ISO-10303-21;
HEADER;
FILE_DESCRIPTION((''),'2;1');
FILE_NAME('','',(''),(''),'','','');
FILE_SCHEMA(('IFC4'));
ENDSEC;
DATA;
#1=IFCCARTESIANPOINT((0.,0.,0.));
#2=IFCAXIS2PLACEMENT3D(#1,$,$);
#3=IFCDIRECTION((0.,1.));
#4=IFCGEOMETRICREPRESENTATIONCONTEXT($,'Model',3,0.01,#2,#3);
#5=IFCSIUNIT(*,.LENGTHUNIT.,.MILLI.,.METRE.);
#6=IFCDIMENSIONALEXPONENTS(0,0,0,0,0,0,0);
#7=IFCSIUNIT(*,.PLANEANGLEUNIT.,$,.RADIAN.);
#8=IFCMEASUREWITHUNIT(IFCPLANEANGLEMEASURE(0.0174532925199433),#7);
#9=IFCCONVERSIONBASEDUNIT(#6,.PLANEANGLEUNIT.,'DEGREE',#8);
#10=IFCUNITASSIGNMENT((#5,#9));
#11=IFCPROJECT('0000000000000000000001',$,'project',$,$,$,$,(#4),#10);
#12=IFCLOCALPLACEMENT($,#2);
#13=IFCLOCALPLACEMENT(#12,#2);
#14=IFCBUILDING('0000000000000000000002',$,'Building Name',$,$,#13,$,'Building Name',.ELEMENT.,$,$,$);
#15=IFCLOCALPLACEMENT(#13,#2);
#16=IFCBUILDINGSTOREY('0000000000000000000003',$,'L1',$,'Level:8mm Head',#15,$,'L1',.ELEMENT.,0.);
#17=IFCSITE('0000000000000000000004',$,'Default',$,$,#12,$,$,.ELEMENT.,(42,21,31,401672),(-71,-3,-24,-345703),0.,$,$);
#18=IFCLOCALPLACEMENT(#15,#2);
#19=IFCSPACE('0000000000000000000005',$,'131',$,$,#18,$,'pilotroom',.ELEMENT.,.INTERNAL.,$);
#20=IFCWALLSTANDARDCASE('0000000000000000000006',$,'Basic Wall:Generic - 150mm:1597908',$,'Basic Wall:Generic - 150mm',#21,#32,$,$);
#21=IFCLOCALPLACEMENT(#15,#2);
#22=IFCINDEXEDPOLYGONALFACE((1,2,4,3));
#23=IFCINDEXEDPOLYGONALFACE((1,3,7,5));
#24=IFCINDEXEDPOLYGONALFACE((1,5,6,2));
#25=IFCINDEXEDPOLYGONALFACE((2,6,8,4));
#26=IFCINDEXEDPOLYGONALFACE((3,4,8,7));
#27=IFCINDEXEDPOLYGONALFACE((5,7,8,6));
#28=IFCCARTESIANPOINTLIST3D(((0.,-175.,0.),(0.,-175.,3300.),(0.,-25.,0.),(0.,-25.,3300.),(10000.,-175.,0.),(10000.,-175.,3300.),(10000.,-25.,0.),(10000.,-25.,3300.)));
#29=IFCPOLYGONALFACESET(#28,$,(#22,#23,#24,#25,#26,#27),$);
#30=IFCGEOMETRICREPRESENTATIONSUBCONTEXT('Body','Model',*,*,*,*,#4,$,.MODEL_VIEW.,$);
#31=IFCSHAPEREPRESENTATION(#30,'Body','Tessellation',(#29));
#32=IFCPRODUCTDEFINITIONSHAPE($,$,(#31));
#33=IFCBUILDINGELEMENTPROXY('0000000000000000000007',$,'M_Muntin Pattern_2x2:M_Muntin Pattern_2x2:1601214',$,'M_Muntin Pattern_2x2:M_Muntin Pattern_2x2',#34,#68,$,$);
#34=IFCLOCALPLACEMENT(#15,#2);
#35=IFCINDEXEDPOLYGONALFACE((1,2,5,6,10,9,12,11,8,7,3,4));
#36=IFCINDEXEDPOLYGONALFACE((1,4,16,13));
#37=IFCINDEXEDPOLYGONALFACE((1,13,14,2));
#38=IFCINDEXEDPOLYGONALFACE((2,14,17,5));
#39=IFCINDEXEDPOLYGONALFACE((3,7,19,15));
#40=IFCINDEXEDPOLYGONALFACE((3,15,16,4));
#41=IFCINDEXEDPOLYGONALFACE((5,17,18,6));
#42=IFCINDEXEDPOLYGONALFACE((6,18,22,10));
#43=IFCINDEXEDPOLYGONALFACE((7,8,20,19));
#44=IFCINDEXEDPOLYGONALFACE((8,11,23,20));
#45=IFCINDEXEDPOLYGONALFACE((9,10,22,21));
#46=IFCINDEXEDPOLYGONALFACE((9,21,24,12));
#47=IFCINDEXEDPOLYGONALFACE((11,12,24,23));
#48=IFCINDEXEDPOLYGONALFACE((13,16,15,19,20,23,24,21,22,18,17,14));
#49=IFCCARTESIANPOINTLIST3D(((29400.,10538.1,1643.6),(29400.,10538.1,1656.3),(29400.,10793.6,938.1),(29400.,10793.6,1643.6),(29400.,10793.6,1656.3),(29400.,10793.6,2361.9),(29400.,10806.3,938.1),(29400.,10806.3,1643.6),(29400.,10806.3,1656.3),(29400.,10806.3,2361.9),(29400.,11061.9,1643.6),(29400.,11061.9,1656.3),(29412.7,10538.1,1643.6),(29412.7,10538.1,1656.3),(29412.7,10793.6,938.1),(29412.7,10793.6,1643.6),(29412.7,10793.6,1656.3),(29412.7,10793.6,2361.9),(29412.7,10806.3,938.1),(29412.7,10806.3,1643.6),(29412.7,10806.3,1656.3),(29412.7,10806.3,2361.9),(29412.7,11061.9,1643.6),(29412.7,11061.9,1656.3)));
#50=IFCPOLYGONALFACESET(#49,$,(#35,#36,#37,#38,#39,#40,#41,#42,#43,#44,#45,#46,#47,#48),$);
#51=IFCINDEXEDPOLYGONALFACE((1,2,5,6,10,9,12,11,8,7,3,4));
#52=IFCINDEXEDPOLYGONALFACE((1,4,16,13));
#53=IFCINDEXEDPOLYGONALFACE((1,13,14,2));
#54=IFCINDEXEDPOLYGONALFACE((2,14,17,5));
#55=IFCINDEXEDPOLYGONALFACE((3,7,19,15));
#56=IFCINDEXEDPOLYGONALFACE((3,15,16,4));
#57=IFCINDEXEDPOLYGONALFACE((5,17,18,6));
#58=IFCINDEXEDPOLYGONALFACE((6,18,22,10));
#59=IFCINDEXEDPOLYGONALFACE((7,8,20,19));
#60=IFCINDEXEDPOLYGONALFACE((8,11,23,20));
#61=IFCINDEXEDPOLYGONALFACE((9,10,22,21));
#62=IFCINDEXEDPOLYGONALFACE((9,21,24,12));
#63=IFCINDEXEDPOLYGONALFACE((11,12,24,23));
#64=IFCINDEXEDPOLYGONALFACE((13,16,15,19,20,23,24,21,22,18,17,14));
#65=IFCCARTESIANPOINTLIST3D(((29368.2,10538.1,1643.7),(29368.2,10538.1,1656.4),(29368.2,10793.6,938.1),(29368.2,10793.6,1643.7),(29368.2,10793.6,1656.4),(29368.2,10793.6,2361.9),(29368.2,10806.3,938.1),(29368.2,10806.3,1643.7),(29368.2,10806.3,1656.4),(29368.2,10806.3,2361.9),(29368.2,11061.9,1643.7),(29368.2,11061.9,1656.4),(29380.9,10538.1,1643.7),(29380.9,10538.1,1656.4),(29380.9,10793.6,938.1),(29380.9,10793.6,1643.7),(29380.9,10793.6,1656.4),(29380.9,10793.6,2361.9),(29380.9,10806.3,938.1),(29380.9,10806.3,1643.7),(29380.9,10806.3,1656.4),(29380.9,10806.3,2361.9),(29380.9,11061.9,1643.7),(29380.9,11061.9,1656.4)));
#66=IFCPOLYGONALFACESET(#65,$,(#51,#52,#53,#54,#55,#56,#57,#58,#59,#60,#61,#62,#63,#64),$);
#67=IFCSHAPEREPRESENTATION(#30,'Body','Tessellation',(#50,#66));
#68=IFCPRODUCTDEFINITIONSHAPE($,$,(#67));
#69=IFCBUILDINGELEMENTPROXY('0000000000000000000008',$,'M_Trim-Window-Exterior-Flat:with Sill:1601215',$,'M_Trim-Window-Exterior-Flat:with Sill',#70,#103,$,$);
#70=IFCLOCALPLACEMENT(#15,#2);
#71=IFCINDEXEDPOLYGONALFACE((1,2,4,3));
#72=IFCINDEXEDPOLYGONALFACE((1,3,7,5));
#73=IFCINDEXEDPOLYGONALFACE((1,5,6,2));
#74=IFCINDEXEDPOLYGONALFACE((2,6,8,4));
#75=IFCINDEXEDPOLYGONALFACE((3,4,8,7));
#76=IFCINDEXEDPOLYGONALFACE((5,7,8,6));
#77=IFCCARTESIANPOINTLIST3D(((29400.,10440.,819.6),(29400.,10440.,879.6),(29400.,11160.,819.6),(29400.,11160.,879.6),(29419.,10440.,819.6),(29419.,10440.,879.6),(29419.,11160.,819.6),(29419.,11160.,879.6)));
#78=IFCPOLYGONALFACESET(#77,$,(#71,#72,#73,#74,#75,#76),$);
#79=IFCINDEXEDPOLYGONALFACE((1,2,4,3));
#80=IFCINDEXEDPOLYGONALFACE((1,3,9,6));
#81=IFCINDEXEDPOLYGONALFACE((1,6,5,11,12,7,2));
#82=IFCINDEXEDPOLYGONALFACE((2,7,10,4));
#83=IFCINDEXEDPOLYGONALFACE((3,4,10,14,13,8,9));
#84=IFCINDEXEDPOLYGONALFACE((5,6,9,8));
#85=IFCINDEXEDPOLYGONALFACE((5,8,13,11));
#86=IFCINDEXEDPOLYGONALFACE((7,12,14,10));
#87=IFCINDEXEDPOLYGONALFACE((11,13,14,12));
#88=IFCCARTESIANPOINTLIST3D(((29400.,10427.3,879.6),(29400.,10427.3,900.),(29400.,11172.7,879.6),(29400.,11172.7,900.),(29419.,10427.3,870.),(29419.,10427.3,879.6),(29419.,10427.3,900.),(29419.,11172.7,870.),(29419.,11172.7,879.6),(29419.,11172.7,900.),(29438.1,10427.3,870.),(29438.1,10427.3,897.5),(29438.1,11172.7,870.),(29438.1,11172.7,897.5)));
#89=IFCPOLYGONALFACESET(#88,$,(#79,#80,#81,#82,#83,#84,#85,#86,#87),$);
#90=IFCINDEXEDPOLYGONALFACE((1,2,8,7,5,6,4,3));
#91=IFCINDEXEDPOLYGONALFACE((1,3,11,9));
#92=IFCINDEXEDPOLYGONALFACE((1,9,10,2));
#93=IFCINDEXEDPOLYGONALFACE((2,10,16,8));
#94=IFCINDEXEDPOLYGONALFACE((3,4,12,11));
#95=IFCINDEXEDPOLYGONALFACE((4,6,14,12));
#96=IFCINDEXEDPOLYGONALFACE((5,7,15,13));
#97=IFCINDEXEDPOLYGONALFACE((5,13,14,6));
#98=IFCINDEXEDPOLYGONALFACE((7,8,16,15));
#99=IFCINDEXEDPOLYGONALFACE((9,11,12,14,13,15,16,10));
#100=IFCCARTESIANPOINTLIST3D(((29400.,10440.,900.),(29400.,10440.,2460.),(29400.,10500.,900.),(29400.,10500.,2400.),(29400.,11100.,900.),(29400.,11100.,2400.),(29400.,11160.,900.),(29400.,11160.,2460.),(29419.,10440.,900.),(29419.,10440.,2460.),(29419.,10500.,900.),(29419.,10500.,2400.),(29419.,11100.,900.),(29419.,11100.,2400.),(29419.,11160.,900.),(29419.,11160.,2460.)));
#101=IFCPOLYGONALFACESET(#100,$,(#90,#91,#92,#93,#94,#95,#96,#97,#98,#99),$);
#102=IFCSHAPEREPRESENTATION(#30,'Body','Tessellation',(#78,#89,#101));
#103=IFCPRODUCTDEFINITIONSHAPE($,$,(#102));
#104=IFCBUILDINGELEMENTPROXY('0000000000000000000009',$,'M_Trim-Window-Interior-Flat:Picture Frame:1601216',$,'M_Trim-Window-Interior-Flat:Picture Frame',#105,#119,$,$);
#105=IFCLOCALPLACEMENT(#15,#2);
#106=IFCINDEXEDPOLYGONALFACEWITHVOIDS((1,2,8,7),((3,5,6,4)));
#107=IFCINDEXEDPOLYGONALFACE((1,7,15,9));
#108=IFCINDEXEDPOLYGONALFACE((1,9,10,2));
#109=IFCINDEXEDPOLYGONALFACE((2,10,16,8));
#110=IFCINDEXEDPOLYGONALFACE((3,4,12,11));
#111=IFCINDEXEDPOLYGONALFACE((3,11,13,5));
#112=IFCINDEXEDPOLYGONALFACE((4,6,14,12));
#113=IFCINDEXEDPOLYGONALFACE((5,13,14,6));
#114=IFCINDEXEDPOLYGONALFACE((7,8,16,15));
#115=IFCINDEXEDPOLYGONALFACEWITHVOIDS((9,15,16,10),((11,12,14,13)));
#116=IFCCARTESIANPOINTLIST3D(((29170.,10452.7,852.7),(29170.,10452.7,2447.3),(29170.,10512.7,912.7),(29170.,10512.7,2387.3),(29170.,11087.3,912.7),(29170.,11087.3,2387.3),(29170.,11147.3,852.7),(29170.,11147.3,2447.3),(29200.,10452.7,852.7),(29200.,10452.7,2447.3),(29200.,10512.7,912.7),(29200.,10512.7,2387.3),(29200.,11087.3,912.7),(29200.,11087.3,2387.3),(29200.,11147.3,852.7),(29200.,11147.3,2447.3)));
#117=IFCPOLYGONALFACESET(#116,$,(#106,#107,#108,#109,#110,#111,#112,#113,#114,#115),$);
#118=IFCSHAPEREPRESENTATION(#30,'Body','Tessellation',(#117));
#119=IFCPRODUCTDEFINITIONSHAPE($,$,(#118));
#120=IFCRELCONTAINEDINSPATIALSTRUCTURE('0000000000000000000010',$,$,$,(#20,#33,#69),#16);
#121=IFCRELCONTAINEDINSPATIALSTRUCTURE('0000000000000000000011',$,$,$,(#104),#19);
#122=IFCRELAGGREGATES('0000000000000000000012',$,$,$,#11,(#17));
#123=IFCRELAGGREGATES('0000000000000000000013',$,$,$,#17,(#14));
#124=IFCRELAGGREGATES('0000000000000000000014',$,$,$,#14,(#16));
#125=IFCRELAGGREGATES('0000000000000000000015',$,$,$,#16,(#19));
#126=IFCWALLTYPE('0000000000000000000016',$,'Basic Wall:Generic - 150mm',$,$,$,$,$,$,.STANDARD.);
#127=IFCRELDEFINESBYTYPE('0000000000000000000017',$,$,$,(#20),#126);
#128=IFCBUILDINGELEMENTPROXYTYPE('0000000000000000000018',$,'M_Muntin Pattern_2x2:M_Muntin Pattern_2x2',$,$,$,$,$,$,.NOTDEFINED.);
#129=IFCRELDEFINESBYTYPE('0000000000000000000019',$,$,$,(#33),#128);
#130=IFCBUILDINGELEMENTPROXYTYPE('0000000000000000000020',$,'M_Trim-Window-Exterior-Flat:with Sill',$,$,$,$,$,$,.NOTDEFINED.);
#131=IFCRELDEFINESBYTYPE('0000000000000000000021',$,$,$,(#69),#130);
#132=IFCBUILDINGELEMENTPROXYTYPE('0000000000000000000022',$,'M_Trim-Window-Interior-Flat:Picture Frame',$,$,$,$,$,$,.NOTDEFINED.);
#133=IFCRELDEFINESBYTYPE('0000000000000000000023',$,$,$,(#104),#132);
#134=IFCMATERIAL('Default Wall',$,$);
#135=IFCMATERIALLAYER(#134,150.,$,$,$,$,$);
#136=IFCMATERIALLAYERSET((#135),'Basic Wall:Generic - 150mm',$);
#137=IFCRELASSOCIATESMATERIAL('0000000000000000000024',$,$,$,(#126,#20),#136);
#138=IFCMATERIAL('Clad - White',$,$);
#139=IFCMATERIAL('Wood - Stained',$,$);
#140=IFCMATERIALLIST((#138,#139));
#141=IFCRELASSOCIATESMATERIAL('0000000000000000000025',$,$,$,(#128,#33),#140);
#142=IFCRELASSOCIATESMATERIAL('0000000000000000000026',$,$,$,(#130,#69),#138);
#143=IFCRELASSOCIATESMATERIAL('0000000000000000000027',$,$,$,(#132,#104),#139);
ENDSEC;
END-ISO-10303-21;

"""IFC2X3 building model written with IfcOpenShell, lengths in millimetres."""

from ifc_helpers import new_model, entity, si_unit, converted_unit, direction, frame, frame_2d, origin, place, context, subcontext, project, spatial, polyline, rectangle, outline, extrude, source, transform, mapped, material, material_list, layer, layer_set, layer_usage, type_object, type_shapes, element, save


model = new_model("IFC2X3")

# Units and contexts
model_context = context("Model", 3, precision=0.01, world=origin(), true_north=direction((0.0, 1.0)))
body_context = subcontext(model_context, "Body", "Model", "MODEL_VIEW")
ifc_project = project(units=[si_unit("LENGTHUNIT", "METRE", prefix="MILLI"), converted_unit("PLANEANGLEUNIT", "DEGREE", entity("IfcPlaneAngleMeasure", 0.0174532925199433), si_unit("PLANEANGLEUNIT", "RADIAN"), dimensions=[0, 0, 0, 0, 0, 0, 0])], contexts=[model_context])

# Site, building, storey
site_placement = place(None, origin())
site = spatial("IfcSite", under=ifc_project, at=site_placement, Name="Default", CompositionType="ELEMENT", RefLatitude=(42, 21, 31, 401672), RefLongitude=(-71, -3, -24, -345703), RefElevation=0.0)
building_placement = place(site_placement, origin())
building = spatial("IfcBuilding", under=site, at=building_placement, Name="Building Name", LongName="Building Name", CompositionType="ELEMENT")
storey_placement = place(building_placement, origin())
storey = spatial("IfcBuildingStorey", under=building, at=storey_placement, Name="L1", ObjectType="Level:8mm Head", LongName="L1", CompositionType="ELEMENT", Elevation=0.0)

# Shared definitions
ifc_material_1 = material(Name="Default Wall")

# Wall
ifc_layer_1 = layer(ifc_material_1, 150.0)
ifc_layer_set_1 = layer_set([ifc_layer_1], Name="Basic Wall:Generic - 150mm")
ifc_layer_usage_1 = layer_usage(ifc_layer_set_1, "AXIS2", "NEGATIVE", 75.0)
wall_type_1 = type_object("IfcWallType", Name="Basic Wall:Generic - 150mm", PredefinedType="STANDARD", material=ifc_layer_set_1)
wall_1_placement = place(storey_placement, frame((0.0, -100.0, 0.0)))
element("IfcWallStandardCase", 1, at=wall_1_placement, inside=storey, type_object=wall_type_1, material=ifc_layer_usage_1, Name="Basic Wall:Generic - 150mm:1597908", ObjectType="Basic Wall:Generic - 150mm", context=body_context, shape_type="SweptSolid", body=[
    extrude(rectangle(XDim=10000.0, YDim=150.0, at=frame_2d((5000.0, 0.0), x_axis=(-1.0, 0.0))), origin(), (0.0, 0.0, 1.0), 3300.0),
])

# Building element proxies
ifc_material_2 = material(Name="Clad - White")
ifc_material_3 = material(Name="Wood - Stained")
ifc_material_list = material_list([ifc_material_2, ifc_material_3])
building_element_proxy_type_1 = type_object("IfcBuildingElementProxyType", Name="M_Muntin Pattern_2x2:M_Muntin Pattern_2x2", PredefinedType="NOTDEFINED", material=ifc_material_list)
shared_shape_1 = source(origin(), body_context, "Body", "SweptSolid", [
    extrude(outline(polyline([(6.4, -6.4), (711.9, -6.4), (711.9, 6.3), (6.4, 6.3), (6.4, 261.9), (-6.3, 261.9), (-6.3, 6.3), (-711.9, 6.3), (-711.9, -6.4), (-6.3, -6.4), (-6.3, -261.9), (6.4, -261.9), (6.4, -6.4)])), frame((0.0, -22.2, 711.9), z_axis=(0.0, 1.0, 0.0), x_axis=(0.0, 0.0, 1.0)), (0.0, 0.0, 1.0), 12.7),
    extrude(outline(polyline([(6.4, -6.4), (711.9, -6.4), (711.9, 6.3), (6.4, 6.3), (6.4, 261.9), (-6.3, 261.9), (-6.3, 6.3), (-711.9, 6.3), (-711.9, -6.4), (-6.3, -6.4), (-6.3, -261.9), (6.4, -261.9), (6.4, -6.4)])), frame((0.0, 9.5, 711.9), z_axis=(0.0, 1.0, 0.0), x_axis=(0.0, 0.0, 1.0)), (0.0, 0.0, 1.0), 12.7),
])
type_shapes(building_element_proxy_type_1, [shared_shape_1])
proxy_1_placement = place(storey_placement, frame((29390.5, 10800.0, 938.1), z_axis=(0.0, 0.0, 1.0), x_axis=(0.0, 1.0, 0.0)))
element("IfcBuildingElementProxy", 2, at=proxy_1_placement, inside=storey, type_object=building_element_proxy_type_1, material=ifc_material_list, Name="M_Muntin Pattern_2x2:M_Muntin Pattern_2x2:1601214", ObjectType="M_Muntin Pattern_2x2:M_Muntin Pattern_2x2", context=body_context, shape_type="MappedRepresentation", body=[
    mapped(shared_shape_1, transform((0.0, 0.0, 0.0), scale=1.0)),
])
building_element_proxy_type_2 = type_object("IfcBuildingElementProxyType", Name="M_Trim-Window-Exterior-Flat:with Sill", PredefinedType="NOTDEFINED", material=ifc_material_2)
shared_shape_2 = source(origin(), body_context, "Body", "SweptSolid", [
    extrude(rectangle(XDim=720.0, YDim=60.0, at=frame_2d((0.0, 0.0), x_axis=(1.0, 0.0))), frame((0.0, -1550.4, 0.0), z_axis=(0.0, 0.0, 1.0), x_axis=(-1.0, 0.0, 0.0)), (0.0, 0.0, 1.0), 19.1),
    extrude(outline(polyline([(-19.0, -15.2), (0.0, -15.2), (0.0, -5.7), (19.0, -5.7), (19.0, 14.8), (0.0, 14.8), (-19.0, 12.3), (-19.0, -15.2)])), frame((-372.7, -1514.8, 19.0), z_axis=(1.0, 0.0, 0.0), x_axis=(0.0, 0.0, -1.0)), (0.0, 0.0, 1.0), 745.4),
    extrude(outline(polyline([(-795.0, -360.0), (765.0, -360.0), (765.0, -300.0), (-735.0, -300.0), (-735.0, 300.0), (765.0, 300.0), (765.0, 360.0), (-795.0, 360.0), (-795.0, -360.0)])), frame((0.0, -735.0, 0.0), z_axis=(0.0, 0.0, 1.0), x_axis=(0.0, -1.0, 0.0)), (0.0, 0.0, 1.0), 19.1),
])
type_shapes(building_element_proxy_type_2, [shared_shape_2])
proxy_2_placement = place(storey_placement, frame((29400.0, 10800.0, 2400.0), z_axis=(1.0, 0.0, 0.0), x_axis=(0.0, 1.0, 0.0)))
element("IfcBuildingElementProxy", 3, at=proxy_2_placement, inside=storey, type_object=building_element_proxy_type_2, material=ifc_material_2, Name="M_Trim-Window-Exterior-Flat:with Sill:1601215", ObjectType="M_Trim-Window-Exterior-Flat:with Sill", context=body_context, shape_type="MappedRepresentation", body=[
    mapped(shared_shape_2, transform((0.0, 0.0, 0.0), scale=1.0)),
])

# Shared definitions
space_placement = place(storey_placement, origin())
space = spatial("IfcSpace", under=storey, at=space_placement, Name="131", LongName="pilotroom", CompositionType="ELEMENT", InteriorOrExteriorSpace="INTERNAL")

# Building element proxy
building_element_proxy_type_3 = type_object("IfcBuildingElementProxyType", Name="M_Trim-Window-Interior-Flat:Picture Frame", PredefinedType="NOTDEFINED", material=ifc_material_3)
shared_shape_3 = source(origin(), body_context, "Body", "SweptSolid", [
    extrude(outline(polyline([(-347.3, -797.3), (347.3, -797.3), (347.3, 797.3), (-347.3, 797.3), (-347.3, -797.3)]), holes=[polyline([(-287.3, -737.3), (-287.3, 737.3), (287.3, 737.3), (287.3, -737.3), (-287.3, -737.3)])]), frame((0.0, -750.0, 0.0), z_axis=(0.0, 0.0, 1.0), x_axis=(-1.0, 0.0, 0.0)), (0.0, 0.0, 1.0), 30.0),
])
type_shapes(building_element_proxy_type_3, [shared_shape_3])
proxy_3_placement = place(space_placement, frame((29200.0, 10800.0, 2400.0), z_axis=(-1.0, 0.0, 0.0), x_axis=(0.0, -1.0, 0.0)))
element("IfcBuildingElementProxy", 4, at=proxy_3_placement, inside=space, type_object=building_element_proxy_type_3, material=ifc_material_3, Name="M_Trim-Window-Interior-Flat:Picture Frame:1601216", ObjectType="M_Trim-Window-Interior-Flat:Picture Frame", context=body_context, shape_type="MappedRepresentation", body=[
    mapped(shared_shape_3, transform((0.0, 0.0, 0.0), scale=1.0)),
])

save(model, "model.ifc")
